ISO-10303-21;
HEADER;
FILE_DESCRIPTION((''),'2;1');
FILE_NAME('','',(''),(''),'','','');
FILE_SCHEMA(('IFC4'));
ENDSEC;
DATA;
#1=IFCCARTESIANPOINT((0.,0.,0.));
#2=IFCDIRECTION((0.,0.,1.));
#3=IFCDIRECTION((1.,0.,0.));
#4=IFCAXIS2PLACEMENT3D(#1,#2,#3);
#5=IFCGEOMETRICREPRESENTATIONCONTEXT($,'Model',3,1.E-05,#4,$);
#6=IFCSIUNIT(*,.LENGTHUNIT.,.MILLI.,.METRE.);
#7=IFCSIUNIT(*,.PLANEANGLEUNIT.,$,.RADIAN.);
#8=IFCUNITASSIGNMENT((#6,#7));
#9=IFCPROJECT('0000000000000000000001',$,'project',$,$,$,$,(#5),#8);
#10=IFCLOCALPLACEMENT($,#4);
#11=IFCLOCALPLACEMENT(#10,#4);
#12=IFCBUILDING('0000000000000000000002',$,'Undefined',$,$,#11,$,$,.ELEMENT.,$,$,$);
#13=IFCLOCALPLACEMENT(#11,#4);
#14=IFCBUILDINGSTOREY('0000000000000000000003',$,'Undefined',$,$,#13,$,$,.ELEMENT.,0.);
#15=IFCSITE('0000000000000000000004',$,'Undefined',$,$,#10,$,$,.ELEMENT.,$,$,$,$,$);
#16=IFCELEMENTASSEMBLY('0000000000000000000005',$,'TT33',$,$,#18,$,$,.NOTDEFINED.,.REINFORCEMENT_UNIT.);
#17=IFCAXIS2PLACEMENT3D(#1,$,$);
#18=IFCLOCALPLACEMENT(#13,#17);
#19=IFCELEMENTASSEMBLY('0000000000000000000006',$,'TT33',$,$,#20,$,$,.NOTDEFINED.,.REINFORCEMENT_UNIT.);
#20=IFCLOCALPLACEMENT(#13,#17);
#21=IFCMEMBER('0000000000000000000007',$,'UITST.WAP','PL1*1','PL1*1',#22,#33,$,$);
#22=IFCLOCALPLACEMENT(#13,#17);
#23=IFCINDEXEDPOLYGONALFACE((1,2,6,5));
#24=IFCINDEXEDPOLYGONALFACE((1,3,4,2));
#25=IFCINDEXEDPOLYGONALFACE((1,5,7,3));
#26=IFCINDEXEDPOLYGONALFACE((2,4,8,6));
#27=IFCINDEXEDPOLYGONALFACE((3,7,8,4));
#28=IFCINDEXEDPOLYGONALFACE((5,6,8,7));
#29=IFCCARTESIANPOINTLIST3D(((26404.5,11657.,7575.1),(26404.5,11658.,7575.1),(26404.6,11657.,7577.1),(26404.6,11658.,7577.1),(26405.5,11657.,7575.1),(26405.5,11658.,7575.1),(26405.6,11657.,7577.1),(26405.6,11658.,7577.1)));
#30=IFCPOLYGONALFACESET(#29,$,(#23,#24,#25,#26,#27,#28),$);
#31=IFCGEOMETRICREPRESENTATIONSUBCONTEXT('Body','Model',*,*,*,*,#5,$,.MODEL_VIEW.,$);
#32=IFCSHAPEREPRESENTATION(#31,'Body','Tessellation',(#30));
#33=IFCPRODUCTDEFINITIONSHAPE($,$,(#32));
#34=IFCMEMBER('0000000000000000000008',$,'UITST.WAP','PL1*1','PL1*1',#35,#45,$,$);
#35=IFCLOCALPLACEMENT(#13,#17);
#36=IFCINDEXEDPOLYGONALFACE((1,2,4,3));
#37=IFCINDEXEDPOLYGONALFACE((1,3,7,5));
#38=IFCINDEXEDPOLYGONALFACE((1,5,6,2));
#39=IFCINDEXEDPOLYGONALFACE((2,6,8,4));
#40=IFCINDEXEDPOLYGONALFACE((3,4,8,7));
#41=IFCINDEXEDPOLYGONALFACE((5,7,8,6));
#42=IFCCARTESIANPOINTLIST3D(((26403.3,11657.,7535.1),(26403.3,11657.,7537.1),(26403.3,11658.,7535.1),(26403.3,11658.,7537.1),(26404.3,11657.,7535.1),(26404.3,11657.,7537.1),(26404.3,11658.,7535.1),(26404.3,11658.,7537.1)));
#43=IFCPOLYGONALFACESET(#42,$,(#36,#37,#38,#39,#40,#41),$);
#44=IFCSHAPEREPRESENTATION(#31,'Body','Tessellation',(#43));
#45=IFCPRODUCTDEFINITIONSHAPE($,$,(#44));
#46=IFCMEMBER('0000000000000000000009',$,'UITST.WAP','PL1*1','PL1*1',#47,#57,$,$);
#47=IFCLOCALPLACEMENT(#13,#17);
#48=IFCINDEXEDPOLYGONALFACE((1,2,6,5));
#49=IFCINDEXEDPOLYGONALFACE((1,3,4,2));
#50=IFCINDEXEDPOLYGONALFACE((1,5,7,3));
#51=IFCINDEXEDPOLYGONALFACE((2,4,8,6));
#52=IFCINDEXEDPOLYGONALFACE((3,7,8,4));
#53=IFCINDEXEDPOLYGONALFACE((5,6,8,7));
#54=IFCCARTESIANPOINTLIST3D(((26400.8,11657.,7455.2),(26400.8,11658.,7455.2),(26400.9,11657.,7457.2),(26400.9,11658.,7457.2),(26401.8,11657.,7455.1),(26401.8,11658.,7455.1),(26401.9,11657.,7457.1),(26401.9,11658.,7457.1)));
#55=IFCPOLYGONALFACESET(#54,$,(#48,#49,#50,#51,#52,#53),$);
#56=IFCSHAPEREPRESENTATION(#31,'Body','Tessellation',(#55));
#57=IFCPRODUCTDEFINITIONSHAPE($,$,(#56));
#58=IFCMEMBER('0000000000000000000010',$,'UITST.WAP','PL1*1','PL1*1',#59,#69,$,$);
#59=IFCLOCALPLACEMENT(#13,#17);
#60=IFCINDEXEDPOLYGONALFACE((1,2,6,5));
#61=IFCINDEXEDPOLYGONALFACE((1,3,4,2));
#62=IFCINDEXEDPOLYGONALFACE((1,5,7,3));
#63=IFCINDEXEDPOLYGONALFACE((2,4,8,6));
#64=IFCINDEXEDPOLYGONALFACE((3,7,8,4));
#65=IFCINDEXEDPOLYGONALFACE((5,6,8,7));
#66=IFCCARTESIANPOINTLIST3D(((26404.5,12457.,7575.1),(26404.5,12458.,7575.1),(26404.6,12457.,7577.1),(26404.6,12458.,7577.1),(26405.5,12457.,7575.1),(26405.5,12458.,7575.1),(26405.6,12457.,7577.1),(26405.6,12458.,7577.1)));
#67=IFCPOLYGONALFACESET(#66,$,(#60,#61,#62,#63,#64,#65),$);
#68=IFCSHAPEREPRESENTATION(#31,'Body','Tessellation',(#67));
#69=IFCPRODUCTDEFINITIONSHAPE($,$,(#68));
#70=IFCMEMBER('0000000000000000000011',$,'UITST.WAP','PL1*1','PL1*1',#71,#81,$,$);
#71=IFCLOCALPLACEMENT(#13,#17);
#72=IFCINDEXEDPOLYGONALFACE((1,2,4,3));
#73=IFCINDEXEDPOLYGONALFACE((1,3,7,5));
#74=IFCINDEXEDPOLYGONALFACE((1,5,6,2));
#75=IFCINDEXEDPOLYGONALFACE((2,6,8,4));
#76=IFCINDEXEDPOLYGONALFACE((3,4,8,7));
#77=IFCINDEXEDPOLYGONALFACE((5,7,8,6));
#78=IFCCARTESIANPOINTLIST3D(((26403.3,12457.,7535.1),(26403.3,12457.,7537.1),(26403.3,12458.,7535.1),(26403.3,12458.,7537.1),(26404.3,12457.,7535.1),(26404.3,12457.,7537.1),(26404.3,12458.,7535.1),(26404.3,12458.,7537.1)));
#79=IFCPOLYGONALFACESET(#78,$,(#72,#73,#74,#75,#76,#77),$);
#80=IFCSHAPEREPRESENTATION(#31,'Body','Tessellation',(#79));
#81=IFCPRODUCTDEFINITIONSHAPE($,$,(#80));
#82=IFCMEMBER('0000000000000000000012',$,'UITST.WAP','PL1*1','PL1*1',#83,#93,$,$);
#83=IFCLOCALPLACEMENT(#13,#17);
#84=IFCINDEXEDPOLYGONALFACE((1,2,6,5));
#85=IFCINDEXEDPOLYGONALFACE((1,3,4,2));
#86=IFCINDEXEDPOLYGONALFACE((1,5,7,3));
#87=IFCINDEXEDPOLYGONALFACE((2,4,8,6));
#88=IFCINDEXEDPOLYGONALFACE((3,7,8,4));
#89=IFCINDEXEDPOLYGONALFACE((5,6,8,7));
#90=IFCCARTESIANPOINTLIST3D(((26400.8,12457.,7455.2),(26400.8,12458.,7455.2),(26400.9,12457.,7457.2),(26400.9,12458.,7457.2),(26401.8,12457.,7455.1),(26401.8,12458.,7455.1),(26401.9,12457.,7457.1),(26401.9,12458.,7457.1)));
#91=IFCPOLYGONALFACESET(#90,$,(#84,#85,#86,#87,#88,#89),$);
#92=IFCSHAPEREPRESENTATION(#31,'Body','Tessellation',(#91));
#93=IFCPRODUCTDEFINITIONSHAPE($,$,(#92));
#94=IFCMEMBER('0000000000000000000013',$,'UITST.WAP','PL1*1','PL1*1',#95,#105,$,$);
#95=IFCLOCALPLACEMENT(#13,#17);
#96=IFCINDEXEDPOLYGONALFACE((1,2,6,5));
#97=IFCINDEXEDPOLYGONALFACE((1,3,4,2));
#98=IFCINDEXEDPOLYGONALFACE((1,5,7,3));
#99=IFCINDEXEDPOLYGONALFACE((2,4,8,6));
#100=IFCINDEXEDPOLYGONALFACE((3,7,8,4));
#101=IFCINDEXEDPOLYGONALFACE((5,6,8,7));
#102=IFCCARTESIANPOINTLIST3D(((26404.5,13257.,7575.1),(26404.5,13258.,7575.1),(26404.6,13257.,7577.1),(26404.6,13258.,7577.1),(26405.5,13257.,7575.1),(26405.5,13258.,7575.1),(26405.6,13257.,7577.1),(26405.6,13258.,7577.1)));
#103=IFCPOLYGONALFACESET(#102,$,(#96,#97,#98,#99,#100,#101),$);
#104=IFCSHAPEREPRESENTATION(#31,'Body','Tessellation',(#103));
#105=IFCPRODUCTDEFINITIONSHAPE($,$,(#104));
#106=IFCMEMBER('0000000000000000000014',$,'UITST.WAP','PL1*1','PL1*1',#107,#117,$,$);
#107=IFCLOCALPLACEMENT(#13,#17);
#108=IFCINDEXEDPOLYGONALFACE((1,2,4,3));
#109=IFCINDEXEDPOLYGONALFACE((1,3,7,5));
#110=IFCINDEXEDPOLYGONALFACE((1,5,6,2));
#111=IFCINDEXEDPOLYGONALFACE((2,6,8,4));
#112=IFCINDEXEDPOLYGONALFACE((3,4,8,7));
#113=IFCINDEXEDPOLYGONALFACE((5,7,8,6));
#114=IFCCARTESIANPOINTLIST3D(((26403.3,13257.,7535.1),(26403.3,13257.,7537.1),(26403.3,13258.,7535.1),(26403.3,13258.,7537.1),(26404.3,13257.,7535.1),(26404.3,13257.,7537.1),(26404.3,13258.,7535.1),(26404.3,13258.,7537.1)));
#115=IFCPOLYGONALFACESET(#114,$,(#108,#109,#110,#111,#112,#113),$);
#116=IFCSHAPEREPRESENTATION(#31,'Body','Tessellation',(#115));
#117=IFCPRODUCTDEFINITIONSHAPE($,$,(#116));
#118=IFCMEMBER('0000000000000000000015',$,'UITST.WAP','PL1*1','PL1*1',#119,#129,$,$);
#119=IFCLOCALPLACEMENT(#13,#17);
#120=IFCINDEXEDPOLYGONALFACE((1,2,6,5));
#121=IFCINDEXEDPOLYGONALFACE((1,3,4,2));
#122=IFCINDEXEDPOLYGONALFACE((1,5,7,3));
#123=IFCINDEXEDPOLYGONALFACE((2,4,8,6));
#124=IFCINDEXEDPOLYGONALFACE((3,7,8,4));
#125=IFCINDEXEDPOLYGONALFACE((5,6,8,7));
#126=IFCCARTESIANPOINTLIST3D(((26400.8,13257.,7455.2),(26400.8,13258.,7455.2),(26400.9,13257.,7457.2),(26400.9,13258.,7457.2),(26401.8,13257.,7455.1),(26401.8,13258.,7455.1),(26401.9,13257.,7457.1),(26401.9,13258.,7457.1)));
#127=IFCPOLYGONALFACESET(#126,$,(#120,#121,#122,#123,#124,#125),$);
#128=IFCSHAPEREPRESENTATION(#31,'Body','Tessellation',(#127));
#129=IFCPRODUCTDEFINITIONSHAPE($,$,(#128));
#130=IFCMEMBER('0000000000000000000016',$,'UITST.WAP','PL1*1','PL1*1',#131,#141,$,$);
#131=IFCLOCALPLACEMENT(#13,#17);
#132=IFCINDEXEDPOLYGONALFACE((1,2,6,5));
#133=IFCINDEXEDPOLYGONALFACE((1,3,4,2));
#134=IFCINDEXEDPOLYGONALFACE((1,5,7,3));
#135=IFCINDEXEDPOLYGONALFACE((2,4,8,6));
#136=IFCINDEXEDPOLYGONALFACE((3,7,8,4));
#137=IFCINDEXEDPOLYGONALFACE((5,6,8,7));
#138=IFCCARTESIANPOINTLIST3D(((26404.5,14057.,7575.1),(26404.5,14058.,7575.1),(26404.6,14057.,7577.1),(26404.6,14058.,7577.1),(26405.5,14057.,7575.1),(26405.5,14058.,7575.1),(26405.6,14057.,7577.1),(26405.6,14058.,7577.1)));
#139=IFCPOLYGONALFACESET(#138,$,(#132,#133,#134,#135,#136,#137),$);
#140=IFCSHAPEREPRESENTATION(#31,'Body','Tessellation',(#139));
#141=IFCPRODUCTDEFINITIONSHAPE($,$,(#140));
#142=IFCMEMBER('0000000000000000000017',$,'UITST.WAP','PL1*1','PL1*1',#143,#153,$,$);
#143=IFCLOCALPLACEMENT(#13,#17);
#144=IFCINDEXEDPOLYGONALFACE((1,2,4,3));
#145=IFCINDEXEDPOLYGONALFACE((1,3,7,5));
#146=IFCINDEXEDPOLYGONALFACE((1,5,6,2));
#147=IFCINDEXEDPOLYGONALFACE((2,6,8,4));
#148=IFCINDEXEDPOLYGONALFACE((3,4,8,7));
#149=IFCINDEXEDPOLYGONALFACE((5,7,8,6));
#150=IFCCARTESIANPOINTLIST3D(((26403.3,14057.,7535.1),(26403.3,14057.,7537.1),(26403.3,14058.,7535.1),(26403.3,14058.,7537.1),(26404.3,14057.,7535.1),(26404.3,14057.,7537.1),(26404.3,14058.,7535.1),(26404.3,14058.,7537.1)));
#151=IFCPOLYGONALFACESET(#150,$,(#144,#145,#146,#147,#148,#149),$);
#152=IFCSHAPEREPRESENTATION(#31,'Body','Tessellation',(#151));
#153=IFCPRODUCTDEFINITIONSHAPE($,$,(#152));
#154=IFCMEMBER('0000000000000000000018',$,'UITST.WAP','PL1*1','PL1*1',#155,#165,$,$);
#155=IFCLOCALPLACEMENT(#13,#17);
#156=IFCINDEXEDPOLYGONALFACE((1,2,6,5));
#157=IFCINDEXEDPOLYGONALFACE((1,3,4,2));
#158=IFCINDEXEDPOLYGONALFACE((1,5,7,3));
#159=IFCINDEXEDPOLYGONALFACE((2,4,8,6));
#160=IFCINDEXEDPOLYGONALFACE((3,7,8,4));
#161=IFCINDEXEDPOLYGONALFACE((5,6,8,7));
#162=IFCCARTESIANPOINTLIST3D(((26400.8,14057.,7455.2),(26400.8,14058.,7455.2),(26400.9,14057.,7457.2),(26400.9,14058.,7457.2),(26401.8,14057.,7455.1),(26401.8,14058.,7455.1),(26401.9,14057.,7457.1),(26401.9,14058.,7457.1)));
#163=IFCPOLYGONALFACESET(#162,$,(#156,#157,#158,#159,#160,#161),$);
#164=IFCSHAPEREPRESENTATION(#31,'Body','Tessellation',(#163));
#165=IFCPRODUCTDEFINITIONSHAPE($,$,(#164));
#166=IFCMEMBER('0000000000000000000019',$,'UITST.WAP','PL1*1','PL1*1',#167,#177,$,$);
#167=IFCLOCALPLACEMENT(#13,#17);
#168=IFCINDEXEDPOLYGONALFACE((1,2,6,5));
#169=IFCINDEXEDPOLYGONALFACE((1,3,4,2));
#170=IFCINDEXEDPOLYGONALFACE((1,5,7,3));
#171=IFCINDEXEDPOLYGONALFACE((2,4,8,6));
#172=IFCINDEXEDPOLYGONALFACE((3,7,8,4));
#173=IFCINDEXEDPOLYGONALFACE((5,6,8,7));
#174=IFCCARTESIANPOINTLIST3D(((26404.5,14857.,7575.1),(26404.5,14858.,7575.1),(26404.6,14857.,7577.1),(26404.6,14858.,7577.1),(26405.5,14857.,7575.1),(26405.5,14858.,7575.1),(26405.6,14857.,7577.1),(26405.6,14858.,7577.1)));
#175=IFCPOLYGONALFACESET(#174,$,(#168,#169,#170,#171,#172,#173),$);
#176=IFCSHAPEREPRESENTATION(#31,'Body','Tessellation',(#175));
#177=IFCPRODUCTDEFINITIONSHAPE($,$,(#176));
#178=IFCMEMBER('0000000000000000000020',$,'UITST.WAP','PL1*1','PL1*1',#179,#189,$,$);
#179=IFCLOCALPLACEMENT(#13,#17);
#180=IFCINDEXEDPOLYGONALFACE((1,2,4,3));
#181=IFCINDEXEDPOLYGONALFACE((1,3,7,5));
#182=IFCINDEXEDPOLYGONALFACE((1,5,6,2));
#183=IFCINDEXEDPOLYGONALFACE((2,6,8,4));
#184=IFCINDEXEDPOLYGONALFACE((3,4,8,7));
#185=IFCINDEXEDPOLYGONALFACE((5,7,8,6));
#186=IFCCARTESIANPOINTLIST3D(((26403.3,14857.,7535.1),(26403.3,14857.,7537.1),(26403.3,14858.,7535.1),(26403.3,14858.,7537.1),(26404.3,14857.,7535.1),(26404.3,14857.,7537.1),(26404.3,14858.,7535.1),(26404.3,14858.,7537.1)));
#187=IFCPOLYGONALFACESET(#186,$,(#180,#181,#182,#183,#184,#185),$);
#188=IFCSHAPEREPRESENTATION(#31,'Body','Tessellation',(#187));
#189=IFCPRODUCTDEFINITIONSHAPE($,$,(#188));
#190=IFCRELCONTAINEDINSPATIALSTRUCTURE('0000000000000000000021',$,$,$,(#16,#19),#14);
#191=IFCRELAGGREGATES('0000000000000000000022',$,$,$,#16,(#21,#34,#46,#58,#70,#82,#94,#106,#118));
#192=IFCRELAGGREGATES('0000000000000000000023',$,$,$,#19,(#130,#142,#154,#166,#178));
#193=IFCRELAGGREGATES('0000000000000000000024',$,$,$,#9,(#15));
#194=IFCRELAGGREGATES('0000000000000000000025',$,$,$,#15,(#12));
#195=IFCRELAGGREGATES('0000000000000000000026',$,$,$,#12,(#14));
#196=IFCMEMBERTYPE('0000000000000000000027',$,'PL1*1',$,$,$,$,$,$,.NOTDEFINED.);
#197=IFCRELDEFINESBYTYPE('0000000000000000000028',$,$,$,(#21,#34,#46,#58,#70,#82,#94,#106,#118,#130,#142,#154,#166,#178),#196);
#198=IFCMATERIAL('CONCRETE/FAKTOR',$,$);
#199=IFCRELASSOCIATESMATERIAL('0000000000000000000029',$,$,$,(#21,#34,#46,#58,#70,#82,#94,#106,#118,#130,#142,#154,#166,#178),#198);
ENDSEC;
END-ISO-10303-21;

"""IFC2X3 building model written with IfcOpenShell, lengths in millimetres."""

from ifc_helpers import new_model, si_unit, frame, frame_2d, origin_with_axes, place, context, subcontext, project, spatial, rectangle, extrude, material, type_object, element, aggregate, save


model = new_model("IFC2X3")

# Units and contexts
model_context = context("Model", 3, precision=1e-05, world=origin_with_axes())
body_context = subcontext(model_context, "Body", "Model", "MODEL_VIEW")
ifc_project = project(units=[si_unit("LENGTHUNIT", "METRE", prefix="MILLI"), si_unit("PLANEANGLEUNIT", "RADIAN")], contexts=[model_context])

# Site, building, storey
site_placement = place(None, origin_with_axes())
site = spatial("IfcSite", under=ifc_project, at=site_placement, Name="Undefined", CompositionType="ELEMENT")
building_placement = place(site_placement, origin_with_axes())
building = spatial("IfcBuilding", under=site, at=building_placement, Name="Undefined", CompositionType="ELEMENT")
storey_placement = place(building_placement, origin_with_axes())
storey = spatial("IfcBuildingStorey", under=building, at=storey_placement, Name="Undefined", CompositionType="ELEMENT", Elevation=0.0)

# Shared definitions
ifc_material_1 = material(Name="CONCRETE/FAKTOR")

# Element assemblies
assembly_1_placement = place(storey_placement, origin_with_axes())
assembly_1 = element("IfcElementAssembly", 1, at=assembly_1_placement, inside=storey, Name="TT33", AssemblyPlace="NOTDEFINED", PredefinedType="REINFORCEMENT_UNIT")
assembly_2_placement = place(storey_placement, origin_with_axes())
assembly_2 = element("IfcElementAssembly", 2, at=assembly_2_placement, inside=storey, Name="TT33", AssemblyPlace="NOTDEFINED", PredefinedType="REINFORCEMENT_UNIT")

# Members
member_type = type_object("IfcMemberType", Name="PL1*1", PredefinedType="NOTDEFINED")
member_1_placement = place(assembly_1_placement, frame((26405.0, 11657.5, 7575.1), z_axis=(0.0, -1.0, 0.0), x_axis=(0.031107, 0.0, 0.999516)))
member_1 = element("IfcMember", 3, at=member_1_placement, type_object=member_type, material=ifc_material_1, Name="UITST.WAP", Description="PL1*1", ObjectType="PL1*1", context=body_context, shape_type="SweptSolid", body=[
    extrude(rectangle(XDim=1.0, YDim=1.0, at=frame_2d((0.0, 0.0), x_axis=(1.0, 0.0))), frame((2.0, 0.0, 0.0), z_axis=(-1.0, 0.0, 0.0), x_axis=(0.0, -1.0, 0.0)), (0.0, 0.0, 1.0), 2.0),
])
member_2_placement = place(assembly_1_placement, frame((26403.8, 11657.5, 7535.1), z_axis=(0.0, -1.0, 0.0), x_axis=(0.031107, 0.0, 0.999516)))
member_2 = element("IfcMember", 4, at=member_2_placement, type_object=member_type, material=ifc_material_1, Name="UITST.WAP", Description="PL1*1", ObjectType="PL1*1", context=body_context, shape_type="SweptSolid", body=[
    extrude(rectangle(XDim=1.0, YDim=1.0, at=frame_2d((0.0, 0.0), x_axis=(1.0, 0.0))), frame((2.0, 0.0, 0.0), z_axis=(-1.0, 0.0, 0.0), x_axis=(0.0, -1.0, 0.0)), (0.0, 0.0, 1.0), 2.0),
])
member_3_placement = place(assembly_1_placement, frame((26401.3, 11657.5, 7455.1), z_axis=(0.0, -1.0, 0.0), x_axis=(0.031107, 0.0, 0.999516)))
member_3 = element("IfcMember", 5, at=member_3_placement, type_object=member_type, material=ifc_material_1, Name="UITST.WAP", Description="PL1*1", ObjectType="PL1*1", context=body_context, shape_type="SweptSolid", body=[
    extrude(rectangle(XDim=1.0, YDim=1.0, at=frame_2d((0.0, 0.0), x_axis=(1.0, 0.0))), frame((2.0, 0.0, 0.0), z_axis=(-1.0, 0.0, 0.0), x_axis=(0.0, -1.0, 0.0)), (0.0, 0.0, 1.0), 2.0),
])
member_4_placement = place(assembly_1_placement, frame((26405.0, 12457.5, 7575.1), z_axis=(0.0, -1.0, 0.0), x_axis=(0.031107, 0.0, 0.999516)))
member_4 = element("IfcMember", 6, at=member_4_placement, type_object=member_type, material=ifc_material_1, Name="UITST.WAP", Description="PL1*1", ObjectType="PL1*1", context=body_context, shape_type="SweptSolid", body=[
    extrude(rectangle(XDim=1.0, YDim=1.0, at=frame_2d((0.0, 0.0), x_axis=(1.0, 0.0))), frame((2.0, 0.0, 0.0), z_axis=(-1.0, 0.0, 0.0), x_axis=(0.0, -1.0, 0.0)), (0.0, 0.0, 1.0), 2.0),
])
member_5_placement = place(assembly_1_placement, frame((26403.8, 12457.5, 7535.1), z_axis=(0.0, -1.0, 0.0), x_axis=(0.031107, 0.0, 0.999516)))
member_5 = element("IfcMember", 7, at=member_5_placement, type_object=member_type, material=ifc_material_1, Name="UITST.WAP", Description="PL1*1", ObjectType="PL1*1", context=body_context, shape_type="SweptSolid", body=[
    extrude(rectangle(XDim=1.0, YDim=1.0, at=frame_2d((0.0, 0.0), x_axis=(1.0, 0.0))), frame((2.0, 0.0, 0.0), z_axis=(-1.0, 0.0, 0.0), x_axis=(0.0, -1.0, 0.0)), (0.0, 0.0, 1.0), 2.0),
])
member_6_placement = place(assembly_1_placement, frame((26401.3, 12457.5, 7455.1), z_axis=(0.0, -1.0, 0.0), x_axis=(0.031107, 0.0, 0.999516)))
member_6 = element("IfcMember", 8, at=member_6_placement, type_object=member_type, material=ifc_material_1, Name="UITST.WAP", Description="PL1*1", ObjectType="PL1*1", context=body_context, shape_type="SweptSolid", body=[
    extrude(rectangle(XDim=1.0, YDim=1.0, at=frame_2d((0.0, 0.0), x_axis=(1.0, 0.0))), frame((2.0, 0.0, 0.0), z_axis=(-1.0, 0.0, 0.0), x_axis=(0.0, -1.0, 0.0)), (0.0, 0.0, 1.0), 2.0),
])
member_7_placement = place(assembly_1_placement, frame((26405.0, 13257.5, 7575.1), z_axis=(0.0, -1.0, 0.0), x_axis=(0.031107, 0.0, 0.999516)))
member_7 = element("IfcMember", 9, at=member_7_placement, type_object=member_type, material=ifc_material_1, Name="UITST.WAP", Description="PL1*1", ObjectType="PL1*1", context=body_context, shape_type="SweptSolid", body=[
    extrude(rectangle(XDim=1.0, YDim=1.0, at=frame_2d((0.0, 0.0), x_axis=(1.0, 0.0))), frame((2.0, 0.0, 0.0), z_axis=(-1.0, 0.0, 0.0), x_axis=(0.0, -1.0, 0.0)), (0.0, 0.0, 1.0), 2.0),
])
member_8_placement = place(assembly_1_placement, frame((26403.8, 13257.5, 7535.1), z_axis=(0.0, -1.0, 0.0), x_axis=(0.031107, 0.0, 0.999516)))
member_8 = element("IfcMember", 10, at=member_8_placement, type_object=member_type, material=ifc_material_1, Name="UITST.WAP", Description="PL1*1", ObjectType="PL1*1", context=body_context, shape_type="SweptSolid", body=[
    extrude(rectangle(XDim=1.0, YDim=1.0, at=frame_2d((0.0, 0.0), x_axis=(1.0, 0.0))), frame((2.0, 0.0, 0.0), z_axis=(-1.0, 0.0, 0.0), x_axis=(0.0, -1.0, 0.0)), (0.0, 0.0, 1.0), 2.0),
])
member_9_placement = place(assembly_1_placement, frame((26401.3, 13257.5, 7455.1), z_axis=(0.0, -1.0, 0.0), x_axis=(0.031107, 0.0, 0.999516)))
member_9 = element("IfcMember", 11, at=member_9_placement, type_object=member_type, material=ifc_material_1, Name="UITST.WAP", Description="PL1*1", ObjectType="PL1*1", context=body_context, shape_type="SweptSolid", body=[
    extrude(rectangle(XDim=1.0, YDim=1.0, at=frame_2d((0.0, 0.0), x_axis=(1.0, 0.0))), frame((2.0, 0.0, 0.0), z_axis=(-1.0, 0.0, 0.0), x_axis=(0.0, -1.0, 0.0)), (0.0, 0.0, 1.0), 2.0),
])
aggregate(assembly_1, [member_1, member_2, member_3, member_4, member_5, member_6, member_7, member_8, member_9])
member_10_placement = place(assembly_2_placement, frame((26405.0, 14057.5, 7575.1), z_axis=(0.0, -1.0, 0.0), x_axis=(0.031107, 0.0, 0.999516)))
member_10 = element("IfcMember", 12, at=member_10_placement, type_object=member_type, material=ifc_material_1, Name="UITST.WAP", Description="PL1*1", ObjectType="PL1*1", context=body_context, shape_type="SweptSolid", body=[
    extrude(rectangle(XDim=1.0, YDim=1.0, at=frame_2d((0.0, 0.0), x_axis=(1.0, 0.0))), frame((2.0, 0.0, 0.0), z_axis=(-1.0, 0.0, 0.0), x_axis=(0.0, -1.0, 0.0)), (0.0, 0.0, 1.0), 2.0),
])
member_11_placement = place(assembly_2_placement, frame((26403.8, 14057.5, 7535.1), z_axis=(0.0, -1.0, 0.0), x_axis=(0.031107, 0.0, 0.999516)))
member_11 = element("IfcMember", 13, at=member_11_placement, type_object=member_type, material=ifc_material_1, Name="UITST.WAP", Description="PL1*1", ObjectType="PL1*1", context=body_context, shape_type="SweptSolid", body=[
    extrude(rectangle(XDim=1.0, YDim=1.0, at=frame_2d((0.0, 0.0), x_axis=(1.0, 0.0))), frame((2.0, 0.0, 0.0), z_axis=(-1.0, 0.0, 0.0), x_axis=(0.0, -1.0, 0.0)), (0.0, 0.0, 1.0), 2.0),
])
member_12_placement = place(assembly_2_placement, frame((26401.3, 14057.5, 7455.1), z_axis=(0.0, -1.0, 0.0), x_axis=(0.031107, 0.0, 0.999516)))
member_12 = element("IfcMember", 14, at=member_12_placement, type_object=member_type, material=ifc_material_1, Name="UITST.WAP", Description="PL1*1", ObjectType="PL1*1", context=body_context, shape_type="SweptSolid", body=[
    extrude(rectangle(XDim=1.0, YDim=1.0, at=frame_2d((0.0, 0.0), x_axis=(1.0, 0.0))), frame((2.0, 0.0, 0.0), z_axis=(-1.0, 0.0, 0.0), x_axis=(0.0, -1.0, 0.0)), (0.0, 0.0, 1.0), 2.0),
])
member_13_placement = place(assembly_2_placement, frame((26405.0, 14857.5, 7575.1), z_axis=(0.0, -1.0, 0.0), x_axis=(0.031107, 0.0, 0.999516)))
member_13 = element("IfcMember", 15, at=member_13_placement, type_object=member_type, material=ifc_material_1, Name="UITST.WAP", Description="PL1*1", ObjectType="PL1*1", context=body_context, shape_type="SweptSolid", body=[
    extrude(rectangle(XDim=1.0, YDim=1.0, at=frame_2d((0.0, 0.0), x_axis=(1.0, 0.0))), frame((2.0, 0.0, 0.0), z_axis=(-1.0, 0.0, 0.0), x_axis=(0.0, -1.0, 0.0)), (0.0, 0.0, 1.0), 2.0),
])
member_14_placement = place(assembly_2_placement, frame((26403.8, 14857.5, 7535.1), z_axis=(0.0, -1.0, 0.0), x_axis=(0.031107, 0.0, 0.999516)))
member_14 = element("IfcMember", 16, at=member_14_placement, type_object=member_type, material=ifc_material_1, Name="UITST.WAP", Description="PL1*1", ObjectType="PL1*1", context=body_context, shape_type="SweptSolid", body=[
    extrude(rectangle(XDim=1.0, YDim=1.0, at=frame_2d((0.0, 0.0), x_axis=(1.0, 0.0))), frame((2.0, 0.0, 0.0), z_axis=(-1.0, 0.0, 0.0), x_axis=(0.0, -1.0, 0.0)), (0.0, 0.0, 1.0), 2.0),
])
aggregate(assembly_2, [member_10, member_11, member_12, member_13, member_14])

save(model, "model.ifc")
